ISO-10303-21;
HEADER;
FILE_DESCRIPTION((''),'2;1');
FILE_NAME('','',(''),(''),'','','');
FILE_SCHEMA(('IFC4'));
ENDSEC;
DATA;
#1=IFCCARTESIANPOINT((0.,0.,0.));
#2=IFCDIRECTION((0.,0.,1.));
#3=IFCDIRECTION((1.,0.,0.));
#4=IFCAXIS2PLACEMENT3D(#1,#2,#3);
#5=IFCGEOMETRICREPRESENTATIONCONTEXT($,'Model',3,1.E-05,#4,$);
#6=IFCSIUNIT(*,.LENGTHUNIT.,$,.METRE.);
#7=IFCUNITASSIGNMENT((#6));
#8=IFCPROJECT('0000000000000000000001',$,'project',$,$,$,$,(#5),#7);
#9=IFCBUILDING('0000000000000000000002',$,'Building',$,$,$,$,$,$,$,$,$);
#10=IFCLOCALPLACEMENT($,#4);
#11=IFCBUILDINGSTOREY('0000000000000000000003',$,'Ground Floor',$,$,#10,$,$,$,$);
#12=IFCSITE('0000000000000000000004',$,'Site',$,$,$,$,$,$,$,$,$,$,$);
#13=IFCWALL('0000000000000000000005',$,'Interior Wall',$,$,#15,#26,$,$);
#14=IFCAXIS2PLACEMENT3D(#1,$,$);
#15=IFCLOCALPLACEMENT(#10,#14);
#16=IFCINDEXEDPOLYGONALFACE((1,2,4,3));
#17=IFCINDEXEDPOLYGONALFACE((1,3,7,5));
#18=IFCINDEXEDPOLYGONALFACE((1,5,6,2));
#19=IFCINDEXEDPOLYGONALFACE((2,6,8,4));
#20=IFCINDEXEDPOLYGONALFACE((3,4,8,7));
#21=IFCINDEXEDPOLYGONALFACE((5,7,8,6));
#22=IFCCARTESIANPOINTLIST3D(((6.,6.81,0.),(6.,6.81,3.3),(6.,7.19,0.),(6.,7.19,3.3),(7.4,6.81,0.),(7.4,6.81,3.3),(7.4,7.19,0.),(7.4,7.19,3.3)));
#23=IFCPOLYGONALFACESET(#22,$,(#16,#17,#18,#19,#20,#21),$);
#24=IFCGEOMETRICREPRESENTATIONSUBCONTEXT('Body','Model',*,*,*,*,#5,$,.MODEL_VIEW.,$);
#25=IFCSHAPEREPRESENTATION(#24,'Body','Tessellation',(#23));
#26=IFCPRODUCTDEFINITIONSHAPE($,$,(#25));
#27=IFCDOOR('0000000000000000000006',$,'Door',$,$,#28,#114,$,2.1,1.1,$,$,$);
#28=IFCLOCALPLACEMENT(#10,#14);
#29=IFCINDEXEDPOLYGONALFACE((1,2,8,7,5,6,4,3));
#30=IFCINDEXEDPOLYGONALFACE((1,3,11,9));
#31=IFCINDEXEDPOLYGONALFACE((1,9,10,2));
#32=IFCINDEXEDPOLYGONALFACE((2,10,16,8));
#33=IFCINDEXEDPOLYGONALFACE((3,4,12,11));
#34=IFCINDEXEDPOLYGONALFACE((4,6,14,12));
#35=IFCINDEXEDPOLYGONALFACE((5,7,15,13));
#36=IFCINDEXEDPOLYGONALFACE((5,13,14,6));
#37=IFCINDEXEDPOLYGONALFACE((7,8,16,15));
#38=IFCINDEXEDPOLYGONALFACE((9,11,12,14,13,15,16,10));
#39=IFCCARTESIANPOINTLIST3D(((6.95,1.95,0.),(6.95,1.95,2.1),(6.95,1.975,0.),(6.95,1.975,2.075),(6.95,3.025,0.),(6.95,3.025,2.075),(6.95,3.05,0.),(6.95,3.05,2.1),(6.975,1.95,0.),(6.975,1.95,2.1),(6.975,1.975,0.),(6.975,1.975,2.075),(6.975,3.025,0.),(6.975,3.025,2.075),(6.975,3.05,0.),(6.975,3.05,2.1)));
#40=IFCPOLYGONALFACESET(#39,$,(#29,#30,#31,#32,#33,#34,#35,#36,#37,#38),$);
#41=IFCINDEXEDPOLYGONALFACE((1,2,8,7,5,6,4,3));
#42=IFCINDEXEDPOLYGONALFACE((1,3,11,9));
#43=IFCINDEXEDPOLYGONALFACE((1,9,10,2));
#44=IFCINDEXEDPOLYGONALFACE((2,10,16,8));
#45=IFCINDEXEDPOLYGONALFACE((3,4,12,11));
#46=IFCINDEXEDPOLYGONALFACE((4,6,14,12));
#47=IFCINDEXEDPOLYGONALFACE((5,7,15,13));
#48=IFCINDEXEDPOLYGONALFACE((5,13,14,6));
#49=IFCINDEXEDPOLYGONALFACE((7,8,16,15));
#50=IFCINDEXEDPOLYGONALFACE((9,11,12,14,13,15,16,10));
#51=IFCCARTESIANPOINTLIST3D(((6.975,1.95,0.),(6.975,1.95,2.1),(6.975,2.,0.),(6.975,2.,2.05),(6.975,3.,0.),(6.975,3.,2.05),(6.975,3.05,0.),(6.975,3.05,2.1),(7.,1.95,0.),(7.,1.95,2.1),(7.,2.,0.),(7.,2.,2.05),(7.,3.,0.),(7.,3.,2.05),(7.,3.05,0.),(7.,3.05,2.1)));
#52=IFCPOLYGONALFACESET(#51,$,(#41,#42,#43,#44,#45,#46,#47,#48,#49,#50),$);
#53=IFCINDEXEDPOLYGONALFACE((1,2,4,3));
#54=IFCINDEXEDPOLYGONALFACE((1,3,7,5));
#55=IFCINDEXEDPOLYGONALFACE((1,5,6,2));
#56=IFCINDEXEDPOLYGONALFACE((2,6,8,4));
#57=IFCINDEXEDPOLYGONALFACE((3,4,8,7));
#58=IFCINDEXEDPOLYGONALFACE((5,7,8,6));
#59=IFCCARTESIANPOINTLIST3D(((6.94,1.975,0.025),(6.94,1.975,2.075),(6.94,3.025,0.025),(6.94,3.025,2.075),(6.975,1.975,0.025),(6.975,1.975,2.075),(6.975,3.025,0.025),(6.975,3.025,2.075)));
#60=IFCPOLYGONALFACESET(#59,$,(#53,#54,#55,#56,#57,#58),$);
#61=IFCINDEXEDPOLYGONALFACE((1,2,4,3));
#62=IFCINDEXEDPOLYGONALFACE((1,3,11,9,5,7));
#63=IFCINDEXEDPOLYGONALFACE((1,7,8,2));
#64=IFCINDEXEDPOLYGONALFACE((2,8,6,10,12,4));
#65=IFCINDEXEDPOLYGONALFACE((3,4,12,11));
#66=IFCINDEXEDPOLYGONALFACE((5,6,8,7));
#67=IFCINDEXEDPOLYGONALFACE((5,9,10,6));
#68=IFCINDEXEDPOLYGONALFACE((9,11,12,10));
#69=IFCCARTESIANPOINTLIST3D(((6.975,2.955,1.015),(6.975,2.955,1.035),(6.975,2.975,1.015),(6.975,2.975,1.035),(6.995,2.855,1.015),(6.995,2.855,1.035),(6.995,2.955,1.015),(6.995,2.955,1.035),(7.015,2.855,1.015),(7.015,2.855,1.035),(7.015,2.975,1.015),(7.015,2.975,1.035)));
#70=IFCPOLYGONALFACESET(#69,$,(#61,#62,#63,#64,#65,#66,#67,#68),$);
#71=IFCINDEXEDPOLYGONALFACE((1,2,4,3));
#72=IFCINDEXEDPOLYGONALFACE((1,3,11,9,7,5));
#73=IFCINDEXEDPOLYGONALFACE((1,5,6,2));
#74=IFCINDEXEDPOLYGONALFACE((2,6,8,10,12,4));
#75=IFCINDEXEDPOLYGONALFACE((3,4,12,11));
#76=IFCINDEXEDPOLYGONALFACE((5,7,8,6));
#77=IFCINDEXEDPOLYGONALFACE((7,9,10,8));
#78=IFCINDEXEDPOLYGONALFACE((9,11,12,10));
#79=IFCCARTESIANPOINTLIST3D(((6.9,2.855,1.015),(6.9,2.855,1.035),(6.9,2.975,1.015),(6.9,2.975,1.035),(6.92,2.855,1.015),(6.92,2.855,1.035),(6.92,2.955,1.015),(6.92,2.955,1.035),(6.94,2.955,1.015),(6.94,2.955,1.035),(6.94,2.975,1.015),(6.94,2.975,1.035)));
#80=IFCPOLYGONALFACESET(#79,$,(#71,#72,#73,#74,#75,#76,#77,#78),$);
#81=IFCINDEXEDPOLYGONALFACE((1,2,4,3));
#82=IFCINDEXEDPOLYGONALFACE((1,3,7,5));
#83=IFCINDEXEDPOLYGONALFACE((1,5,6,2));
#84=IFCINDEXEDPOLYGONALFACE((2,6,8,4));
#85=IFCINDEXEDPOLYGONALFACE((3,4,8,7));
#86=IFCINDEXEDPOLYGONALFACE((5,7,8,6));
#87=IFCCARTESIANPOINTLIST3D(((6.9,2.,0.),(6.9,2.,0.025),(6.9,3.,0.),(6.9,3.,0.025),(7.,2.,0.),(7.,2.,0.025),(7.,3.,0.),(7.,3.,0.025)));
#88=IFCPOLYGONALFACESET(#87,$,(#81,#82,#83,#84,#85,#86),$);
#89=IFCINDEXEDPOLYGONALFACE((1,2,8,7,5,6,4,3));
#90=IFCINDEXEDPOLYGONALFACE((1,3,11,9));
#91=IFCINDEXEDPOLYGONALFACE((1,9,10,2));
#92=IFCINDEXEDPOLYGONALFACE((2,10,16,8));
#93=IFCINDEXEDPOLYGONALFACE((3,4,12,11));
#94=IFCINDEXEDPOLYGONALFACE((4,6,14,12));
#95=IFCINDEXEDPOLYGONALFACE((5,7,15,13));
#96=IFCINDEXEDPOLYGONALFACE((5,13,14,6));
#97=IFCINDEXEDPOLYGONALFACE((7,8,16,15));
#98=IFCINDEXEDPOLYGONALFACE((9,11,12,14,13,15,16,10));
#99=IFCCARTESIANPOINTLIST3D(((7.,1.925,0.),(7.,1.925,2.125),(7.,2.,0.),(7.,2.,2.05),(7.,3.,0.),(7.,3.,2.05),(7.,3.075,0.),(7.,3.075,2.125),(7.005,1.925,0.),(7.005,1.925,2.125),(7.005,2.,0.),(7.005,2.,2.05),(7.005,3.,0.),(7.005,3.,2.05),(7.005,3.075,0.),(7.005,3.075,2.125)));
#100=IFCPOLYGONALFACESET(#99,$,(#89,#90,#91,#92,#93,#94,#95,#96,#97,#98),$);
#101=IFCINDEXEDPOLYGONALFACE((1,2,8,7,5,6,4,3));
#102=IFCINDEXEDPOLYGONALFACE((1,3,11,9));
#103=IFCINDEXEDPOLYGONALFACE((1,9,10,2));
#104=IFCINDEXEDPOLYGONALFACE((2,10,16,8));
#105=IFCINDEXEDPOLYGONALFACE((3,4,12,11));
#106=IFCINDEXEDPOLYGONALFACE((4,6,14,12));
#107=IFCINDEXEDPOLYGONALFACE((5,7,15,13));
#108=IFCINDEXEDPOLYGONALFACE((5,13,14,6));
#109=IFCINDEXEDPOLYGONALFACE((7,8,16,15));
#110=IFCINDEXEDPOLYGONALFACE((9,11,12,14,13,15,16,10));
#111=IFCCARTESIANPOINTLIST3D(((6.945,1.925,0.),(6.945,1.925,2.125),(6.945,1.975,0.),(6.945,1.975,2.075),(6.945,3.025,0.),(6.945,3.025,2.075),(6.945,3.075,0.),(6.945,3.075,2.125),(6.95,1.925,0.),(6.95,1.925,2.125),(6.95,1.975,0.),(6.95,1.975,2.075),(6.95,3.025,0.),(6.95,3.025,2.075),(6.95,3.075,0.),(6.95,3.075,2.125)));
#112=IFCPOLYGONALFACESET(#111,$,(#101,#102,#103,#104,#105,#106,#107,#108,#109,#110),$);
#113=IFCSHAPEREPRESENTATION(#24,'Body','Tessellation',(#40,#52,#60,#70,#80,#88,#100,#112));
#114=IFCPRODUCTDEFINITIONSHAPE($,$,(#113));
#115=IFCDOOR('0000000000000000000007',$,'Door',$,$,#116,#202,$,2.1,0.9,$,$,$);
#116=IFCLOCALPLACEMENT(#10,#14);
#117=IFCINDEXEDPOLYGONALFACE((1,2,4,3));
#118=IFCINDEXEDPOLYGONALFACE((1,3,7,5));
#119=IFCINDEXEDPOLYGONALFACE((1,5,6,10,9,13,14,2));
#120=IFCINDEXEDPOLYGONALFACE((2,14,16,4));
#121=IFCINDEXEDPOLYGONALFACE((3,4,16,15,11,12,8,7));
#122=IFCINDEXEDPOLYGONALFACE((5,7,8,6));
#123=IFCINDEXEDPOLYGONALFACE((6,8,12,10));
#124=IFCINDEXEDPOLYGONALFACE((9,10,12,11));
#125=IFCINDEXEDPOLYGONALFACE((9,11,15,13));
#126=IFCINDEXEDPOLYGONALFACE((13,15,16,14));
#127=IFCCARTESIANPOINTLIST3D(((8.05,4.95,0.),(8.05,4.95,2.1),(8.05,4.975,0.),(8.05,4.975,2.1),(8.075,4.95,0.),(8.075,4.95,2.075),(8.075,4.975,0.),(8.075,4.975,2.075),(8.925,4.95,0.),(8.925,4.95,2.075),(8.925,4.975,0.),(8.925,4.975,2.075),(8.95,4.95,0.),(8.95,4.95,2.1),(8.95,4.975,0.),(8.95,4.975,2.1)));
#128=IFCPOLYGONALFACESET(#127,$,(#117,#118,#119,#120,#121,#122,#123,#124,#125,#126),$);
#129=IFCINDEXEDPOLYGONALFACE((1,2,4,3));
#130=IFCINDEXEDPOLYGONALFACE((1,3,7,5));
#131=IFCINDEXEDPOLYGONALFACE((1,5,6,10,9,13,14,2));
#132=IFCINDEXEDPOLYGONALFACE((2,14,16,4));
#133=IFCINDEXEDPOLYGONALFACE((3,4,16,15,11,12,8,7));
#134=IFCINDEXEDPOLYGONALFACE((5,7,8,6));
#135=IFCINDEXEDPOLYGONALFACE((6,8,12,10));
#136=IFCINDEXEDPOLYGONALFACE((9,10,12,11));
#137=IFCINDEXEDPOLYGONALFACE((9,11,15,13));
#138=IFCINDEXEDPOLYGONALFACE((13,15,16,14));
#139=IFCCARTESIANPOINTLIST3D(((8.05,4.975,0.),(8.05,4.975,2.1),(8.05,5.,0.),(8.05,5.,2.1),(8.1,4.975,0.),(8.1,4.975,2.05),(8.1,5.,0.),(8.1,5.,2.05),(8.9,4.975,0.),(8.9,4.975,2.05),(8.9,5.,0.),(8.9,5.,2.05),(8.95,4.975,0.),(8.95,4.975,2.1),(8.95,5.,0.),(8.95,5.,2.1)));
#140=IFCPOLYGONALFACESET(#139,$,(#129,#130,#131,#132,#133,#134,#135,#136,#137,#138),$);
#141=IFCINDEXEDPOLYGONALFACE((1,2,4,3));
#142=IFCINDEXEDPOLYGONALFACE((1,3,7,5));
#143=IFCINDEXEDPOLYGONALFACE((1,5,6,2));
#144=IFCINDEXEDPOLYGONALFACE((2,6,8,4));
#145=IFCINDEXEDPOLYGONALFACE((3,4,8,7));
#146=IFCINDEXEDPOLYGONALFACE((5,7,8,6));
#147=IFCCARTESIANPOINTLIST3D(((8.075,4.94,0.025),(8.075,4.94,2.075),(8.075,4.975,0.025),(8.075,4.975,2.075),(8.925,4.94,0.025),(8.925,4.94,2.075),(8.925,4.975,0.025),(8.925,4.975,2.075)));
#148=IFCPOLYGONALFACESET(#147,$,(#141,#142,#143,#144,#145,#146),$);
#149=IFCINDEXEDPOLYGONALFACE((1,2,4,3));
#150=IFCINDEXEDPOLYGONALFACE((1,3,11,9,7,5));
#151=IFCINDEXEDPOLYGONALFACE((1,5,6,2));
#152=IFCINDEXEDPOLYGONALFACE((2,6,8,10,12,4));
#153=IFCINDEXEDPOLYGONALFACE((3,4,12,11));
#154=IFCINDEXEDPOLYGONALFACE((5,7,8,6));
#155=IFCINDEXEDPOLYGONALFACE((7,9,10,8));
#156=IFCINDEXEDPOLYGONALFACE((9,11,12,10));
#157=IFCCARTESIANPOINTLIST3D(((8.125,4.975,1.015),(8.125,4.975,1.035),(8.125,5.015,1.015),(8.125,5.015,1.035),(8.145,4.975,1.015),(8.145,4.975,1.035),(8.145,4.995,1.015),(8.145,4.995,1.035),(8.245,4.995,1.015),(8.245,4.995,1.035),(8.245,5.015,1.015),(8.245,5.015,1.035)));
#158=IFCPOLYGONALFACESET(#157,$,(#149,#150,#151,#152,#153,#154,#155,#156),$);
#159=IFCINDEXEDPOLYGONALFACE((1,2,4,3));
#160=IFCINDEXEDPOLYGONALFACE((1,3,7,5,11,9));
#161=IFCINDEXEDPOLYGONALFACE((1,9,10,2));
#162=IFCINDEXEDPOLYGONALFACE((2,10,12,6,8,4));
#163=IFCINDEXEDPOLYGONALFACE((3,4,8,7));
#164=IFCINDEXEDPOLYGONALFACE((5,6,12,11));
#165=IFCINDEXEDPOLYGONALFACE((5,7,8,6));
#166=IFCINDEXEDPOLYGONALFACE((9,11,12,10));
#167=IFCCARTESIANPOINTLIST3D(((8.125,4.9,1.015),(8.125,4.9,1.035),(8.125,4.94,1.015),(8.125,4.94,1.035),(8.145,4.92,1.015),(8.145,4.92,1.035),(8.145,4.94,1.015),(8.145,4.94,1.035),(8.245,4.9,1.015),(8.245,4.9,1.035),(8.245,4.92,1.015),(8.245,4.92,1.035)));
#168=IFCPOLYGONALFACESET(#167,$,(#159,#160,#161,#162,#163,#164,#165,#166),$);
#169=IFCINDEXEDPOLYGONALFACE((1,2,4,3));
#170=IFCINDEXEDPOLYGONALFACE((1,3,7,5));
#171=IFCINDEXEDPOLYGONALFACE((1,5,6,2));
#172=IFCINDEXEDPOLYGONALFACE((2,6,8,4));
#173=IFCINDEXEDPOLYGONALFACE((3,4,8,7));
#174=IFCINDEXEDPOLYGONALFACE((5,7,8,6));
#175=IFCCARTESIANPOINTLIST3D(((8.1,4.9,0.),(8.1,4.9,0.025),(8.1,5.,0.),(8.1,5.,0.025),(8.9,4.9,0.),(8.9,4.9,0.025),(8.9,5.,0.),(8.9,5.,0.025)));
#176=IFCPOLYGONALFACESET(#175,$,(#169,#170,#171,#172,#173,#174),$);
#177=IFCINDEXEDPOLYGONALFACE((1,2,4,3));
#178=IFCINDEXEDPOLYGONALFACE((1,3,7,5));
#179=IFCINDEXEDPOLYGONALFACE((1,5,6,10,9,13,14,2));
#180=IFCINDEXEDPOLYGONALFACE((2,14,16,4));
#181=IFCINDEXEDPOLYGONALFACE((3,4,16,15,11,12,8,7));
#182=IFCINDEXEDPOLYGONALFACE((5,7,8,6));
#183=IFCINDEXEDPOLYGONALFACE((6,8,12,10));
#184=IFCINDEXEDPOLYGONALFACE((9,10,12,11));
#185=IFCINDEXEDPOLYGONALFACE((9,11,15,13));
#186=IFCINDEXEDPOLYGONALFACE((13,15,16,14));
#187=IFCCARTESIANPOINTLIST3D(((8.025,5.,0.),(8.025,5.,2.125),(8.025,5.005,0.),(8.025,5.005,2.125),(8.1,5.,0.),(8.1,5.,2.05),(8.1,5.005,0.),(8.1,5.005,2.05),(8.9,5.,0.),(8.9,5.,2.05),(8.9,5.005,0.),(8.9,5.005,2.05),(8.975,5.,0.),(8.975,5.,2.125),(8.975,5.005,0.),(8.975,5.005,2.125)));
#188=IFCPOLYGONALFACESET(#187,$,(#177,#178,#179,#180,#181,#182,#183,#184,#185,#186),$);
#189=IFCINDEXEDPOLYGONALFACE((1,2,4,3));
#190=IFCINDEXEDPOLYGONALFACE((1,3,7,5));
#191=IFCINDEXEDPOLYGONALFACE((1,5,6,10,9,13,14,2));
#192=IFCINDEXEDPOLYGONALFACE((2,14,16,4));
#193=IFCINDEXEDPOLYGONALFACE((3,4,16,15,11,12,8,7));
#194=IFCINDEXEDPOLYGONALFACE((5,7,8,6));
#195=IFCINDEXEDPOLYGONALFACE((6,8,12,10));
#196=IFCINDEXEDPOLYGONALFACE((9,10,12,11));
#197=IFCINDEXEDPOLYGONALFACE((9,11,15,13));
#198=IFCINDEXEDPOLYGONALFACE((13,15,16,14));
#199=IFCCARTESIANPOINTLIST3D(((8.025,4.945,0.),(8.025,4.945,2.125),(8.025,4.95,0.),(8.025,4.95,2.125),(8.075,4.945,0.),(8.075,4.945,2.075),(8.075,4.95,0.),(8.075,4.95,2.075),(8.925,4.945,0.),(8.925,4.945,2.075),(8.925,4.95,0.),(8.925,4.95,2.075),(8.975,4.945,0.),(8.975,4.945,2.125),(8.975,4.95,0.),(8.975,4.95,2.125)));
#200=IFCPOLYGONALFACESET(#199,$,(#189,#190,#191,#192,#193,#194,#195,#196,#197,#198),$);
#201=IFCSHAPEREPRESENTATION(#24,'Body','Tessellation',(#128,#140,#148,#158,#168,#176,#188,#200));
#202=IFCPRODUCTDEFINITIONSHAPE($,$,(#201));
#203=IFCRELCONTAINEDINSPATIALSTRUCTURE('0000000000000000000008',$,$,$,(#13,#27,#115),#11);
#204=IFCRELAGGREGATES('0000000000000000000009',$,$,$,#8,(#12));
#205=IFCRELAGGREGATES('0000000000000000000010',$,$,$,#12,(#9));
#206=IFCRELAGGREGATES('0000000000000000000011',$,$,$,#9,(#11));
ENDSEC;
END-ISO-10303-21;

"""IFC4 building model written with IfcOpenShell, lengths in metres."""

from ifc_helpers import new_model, si_unit, frame, origin_with_axes, place, context, subcontext, project, spatial, line, indexed_curve, outline, extrude, element, save


model = new_model("IFC4")

# Units and contexts
model_context = context("Model", 3, precision=1e-05, world=origin_with_axes())
body_context = subcontext(model_context, "Body", "Model", "MODEL_VIEW")
ifc_project = project(units=[si_unit("LENGTHUNIT", "METRE")], contexts=[model_context])

# Site, building, storey
site = spatial("IfcSite", under=ifc_project, Name="Site")
building = spatial("IfcBuilding", under=site, Name="Building")
storey_placement = place(None, origin_with_axes())
storey = spatial("IfcBuildingStorey", under=building, at=storey_placement, Name="Ground Floor")

# Wall
for number, where, z_axis, x_axis, name in (
    (1, (7.4, 7.0, 0.0), (0.0, 0.0, 1.0), (-1.0, 0.0, 0.0), "Interior Wall"),
):
    element("IfcWall", number, at=place(storey_placement, frame(where, z_axis=z_axis, x_axis=x_axis)), inside=storey, Name=name, context=body_context, shape_type="SweptSolid", body=[
        extrude(outline(indexed_curve([(0.0, 0.0), (0.0, 0.38), (1.4, 0.38), (1.4, 0.0), (0.0, 0.0)], self_intersect=False)), frame((0.0, -0.19, 0.0), z_axis=(0.0, 0.0, 1.0), x_axis=(1.0, 0.0, 0.0)), (0.0, 0.0, 1.0), 3.3),
    ])

# Doors
door_1_placement = place(storey_placement, frame((7.0, 1.95, 0.0), z_axis=(0.0, 0.0, 1.0), x_axis=(0.0, 1.0, 0.0)))
element("IfcDoor", 2, at=door_1_placement, inside=storey, Name="Door", OverallHeight=2.1, OverallWidth=1.1, context=body_context, shape_type="SweptSolid", body=[
    extrude(outline(indexed_curve([(0.0, 0.0), (0.0, 2.1), (1.1, 2.1), (1.1, 0.0), (1.075, 0.0), (1.075, 2.075), (0.025, 2.075), (0.025, 0.0)], segments=[line(1, 2, 3, 4, 5, 6, 7, 8, 1)])), frame((0.0, 0.025, 0.0), z_axis=(0.0, -1.0, 0.0), x_axis=(1.0, 0.0, 0.0)), (0.0, 0.0, -1.0), 0.025),
    extrude(outline(indexed_curve([(0.0, 0.0), (0.0, 2.1), (1.1, 2.1), (1.1, 0.0), (1.05, 0.0), (1.05, 2.05), (0.05, 2.05), (0.05, 0.0)], segments=[line(1, 2, 3, 4, 5, 6, 7, 8, 1)])), frame((0.0, 0.0, 0.0), z_axis=(0.0, -1.0, 0.0), x_axis=(1.0, 0.0, 0.0)), (0.0, 0.0, -1.0), 0.025),
    extrude(outline(indexed_curve([(0.0, 0.0), (1.05, 0.0), (1.05, 0.035), (0.0, 0.035)], segments=[line(1, 2, 3, 4, 1)])), frame((0.025, 0.025, 0.025), z_axis=(0.0, 0.0, 1.0), x_axis=(1.0, 0.0, 0.0)), (0.0, 0.0, 1.0), 2.05),
    extrude(outline(indexed_curve([(0.0, 0.0), (0.0, -0.04), (-0.12, -0.04), (-0.12, -0.02), (-0.02, -0.02), (-0.02, 0.0)], segments=[line(1, 2, 3, 4, 5, 6, 1)])), frame((1.025, 0.025, 1.015), z_axis=(0.0, 0.0, 1.0), x_axis=(1.0, 0.0, 0.0)), (0.0, 0.0, 1.0), 0.02),
    extrude(outline(indexed_curve([(0.0, 0.0), (0.0, 0.04), (-0.12, 0.04), (-0.12, 0.02), (-0.02, 0.02), (-0.02, 0.0)], segments=[line(1, 2, 3, 4, 5, 6, 1)])), frame((1.025, 0.06, 1.015), z_axis=(0.0, 0.0, 1.0), x_axis=(1.0, 0.0, 0.0)), (0.0, 0.0, 1.0), 0.02),
    extrude(outline(indexed_curve([(0.0, 0.0), (1.0, 0.0), (1.0, 0.1), (0.0, 0.1)], segments=[line(1, 2, 3, 4, 1)])), frame((0.05, 0.0, 0.0), z_axis=(0.0, 0.0, 1.0), x_axis=(1.0, 0.0, 0.0)), (0.0, 0.0, 1.0), 0.025),
    extrude(outline(indexed_curve([(0.0, 0.0), (0.0, 2.125), (1.15, 2.125), (1.15, 0.0), (1.075, 0.0), (1.075, 2.05), (0.075, 2.05), (0.075, 0.0)], segments=[line(1, 2, 3, 4, 5, 6, 7, 8, 1)])), frame((-0.025, -0.005, 0.0), z_axis=(0.0, -1.0, 0.0), x_axis=(1.0, 0.0, 0.0)), (0.0, 0.0, -1.0), 0.005),
    extrude(outline(indexed_curve([(0.0, 0.0), (0.0, 2.125), (1.15, 2.125), (1.15, 0.0), (1.1, 0.0), (1.1, 2.075), (0.05, 2.075), (0.05, 0.0)], segments=[line(1, 2, 3, 4, 5, 6, 7, 8, 1)])), frame((-0.025, 0.05, 0.0), z_axis=(0.0, -1.0, 0.0), x_axis=(1.0, 0.0, 0.0)), (0.0, 0.0, -1.0), 0.005),
])
door_2_placement = place(storey_placement, frame((8.95, 5.0, 0.0), z_axis=(0.0, 0.0, 1.0), x_axis=(-1.0, 0.0, 0.0)))
element("IfcDoor", 3, at=door_2_placement, inside=storey, Name="Door", OverallHeight=2.1, OverallWidth=0.9, context=body_context, shape_type="SweptSolid", body=[
    extrude(outline(indexed_curve([(0.0, 0.0), (0.0, 2.1), (0.9, 2.1), (0.9, 0.0), (0.875, 0.0), (0.875, 2.075), (0.025, 2.075), (0.025, 0.0)], segments=[line(1, 2, 3, 4, 5, 6, 7, 8, 1)])), frame((0.0, 0.025, 0.0), z_axis=(0.0, -1.0, 0.0), x_axis=(1.0, 0.0, 0.0)), (0.0, 0.0, -1.0), 0.025),
    extrude(outline(indexed_curve([(0.0, 0.0), (0.0, 2.1), (0.9, 2.1), (0.9, 0.0), (0.85, 0.0), (0.85, 2.05), (0.05, 2.05), (0.05, 0.0)], segments=[line(1, 2, 3, 4, 5, 6, 7, 8, 1)])), frame((0.0, 0.0, 0.0), z_axis=(0.0, -1.0, 0.0), x_axis=(1.0, 0.0, 0.0)), (0.0, 0.0, -1.0), 0.025),
    extrude(outline(indexed_curve([(0.0, 0.0), (0.85, 0.0), (0.85, 0.035), (0.0, 0.035)], segments=[line(1, 2, 3, 4, 1)])), frame((0.025, 0.025, 0.025), z_axis=(0.0, 0.0, 1.0), x_axis=(1.0, 0.0, 0.0)), (0.0, 0.0, 1.0), 2.05),
    extrude(outline(indexed_curve([(0.0, 0.0), (0.0, -0.04), (-0.12, -0.04), (-0.12, -0.02), (-0.02, -0.02), (-0.02, 0.0)], segments=[line(1, 2, 3, 4, 5, 6, 1)])), frame((0.825, 0.025, 1.015), z_axis=(0.0, 0.0, 1.0), x_axis=(1.0, 0.0, 0.0)), (0.0, 0.0, 1.0), 0.02),
    extrude(outline(indexed_curve([(0.0, 0.0), (0.0, 0.04), (-0.12, 0.04), (-0.12, 0.02), (-0.02, 0.02), (-0.02, 0.0)], segments=[line(1, 2, 3, 4, 5, 6, 1)])), frame((0.825, 0.06, 1.015), z_axis=(0.0, 0.0, 1.0), x_axis=(1.0, 0.0, 0.0)), (0.0, 0.0, 1.0), 0.02),
    extrude(outline(indexed_curve([(0.0, 0.0), (0.8, 0.0), (0.8, 0.1), (0.0, 0.1)], segments=[line(1, 2, 3, 4, 1)])), frame((0.05, 0.0, 0.0), z_axis=(0.0, 0.0, 1.0), x_axis=(1.0, 0.0, 0.0)), (0.0, 0.0, 1.0), 0.025),
    extrude(outline(indexed_curve([(0.0, 0.0), (0.0, 2.125), (0.95, 2.125), (0.95, 0.0), (0.875, 0.0), (0.875, 2.05), (0.075, 2.05), (0.075, 0.0)], segments=[line(1, 2, 3, 4, 5, 6, 7, 8, 1)])), frame((-0.025, -0.005, 0.0), z_axis=(0.0, -1.0, 0.0), x_axis=(1.0, 0.0, 0.0)), (0.0, 0.0, -1.0), 0.005),
    extrude(outline(indexed_curve([(0.0, 0.0), (0.0, 2.125), (0.95, 2.125), (0.95, 0.0), (0.9, 0.0), (0.9, 2.075), (0.05, 2.075), (0.05, 0.0)], segments=[line(1, 2, 3, 4, 5, 6, 7, 8, 1)])), frame((-0.025, 0.05, 0.0), z_axis=(0.0, -1.0, 0.0), x_axis=(1.0, 0.0, 0.0)), (0.0, 0.0, -1.0), 0.005),
])

save(model, "model.ifc")
